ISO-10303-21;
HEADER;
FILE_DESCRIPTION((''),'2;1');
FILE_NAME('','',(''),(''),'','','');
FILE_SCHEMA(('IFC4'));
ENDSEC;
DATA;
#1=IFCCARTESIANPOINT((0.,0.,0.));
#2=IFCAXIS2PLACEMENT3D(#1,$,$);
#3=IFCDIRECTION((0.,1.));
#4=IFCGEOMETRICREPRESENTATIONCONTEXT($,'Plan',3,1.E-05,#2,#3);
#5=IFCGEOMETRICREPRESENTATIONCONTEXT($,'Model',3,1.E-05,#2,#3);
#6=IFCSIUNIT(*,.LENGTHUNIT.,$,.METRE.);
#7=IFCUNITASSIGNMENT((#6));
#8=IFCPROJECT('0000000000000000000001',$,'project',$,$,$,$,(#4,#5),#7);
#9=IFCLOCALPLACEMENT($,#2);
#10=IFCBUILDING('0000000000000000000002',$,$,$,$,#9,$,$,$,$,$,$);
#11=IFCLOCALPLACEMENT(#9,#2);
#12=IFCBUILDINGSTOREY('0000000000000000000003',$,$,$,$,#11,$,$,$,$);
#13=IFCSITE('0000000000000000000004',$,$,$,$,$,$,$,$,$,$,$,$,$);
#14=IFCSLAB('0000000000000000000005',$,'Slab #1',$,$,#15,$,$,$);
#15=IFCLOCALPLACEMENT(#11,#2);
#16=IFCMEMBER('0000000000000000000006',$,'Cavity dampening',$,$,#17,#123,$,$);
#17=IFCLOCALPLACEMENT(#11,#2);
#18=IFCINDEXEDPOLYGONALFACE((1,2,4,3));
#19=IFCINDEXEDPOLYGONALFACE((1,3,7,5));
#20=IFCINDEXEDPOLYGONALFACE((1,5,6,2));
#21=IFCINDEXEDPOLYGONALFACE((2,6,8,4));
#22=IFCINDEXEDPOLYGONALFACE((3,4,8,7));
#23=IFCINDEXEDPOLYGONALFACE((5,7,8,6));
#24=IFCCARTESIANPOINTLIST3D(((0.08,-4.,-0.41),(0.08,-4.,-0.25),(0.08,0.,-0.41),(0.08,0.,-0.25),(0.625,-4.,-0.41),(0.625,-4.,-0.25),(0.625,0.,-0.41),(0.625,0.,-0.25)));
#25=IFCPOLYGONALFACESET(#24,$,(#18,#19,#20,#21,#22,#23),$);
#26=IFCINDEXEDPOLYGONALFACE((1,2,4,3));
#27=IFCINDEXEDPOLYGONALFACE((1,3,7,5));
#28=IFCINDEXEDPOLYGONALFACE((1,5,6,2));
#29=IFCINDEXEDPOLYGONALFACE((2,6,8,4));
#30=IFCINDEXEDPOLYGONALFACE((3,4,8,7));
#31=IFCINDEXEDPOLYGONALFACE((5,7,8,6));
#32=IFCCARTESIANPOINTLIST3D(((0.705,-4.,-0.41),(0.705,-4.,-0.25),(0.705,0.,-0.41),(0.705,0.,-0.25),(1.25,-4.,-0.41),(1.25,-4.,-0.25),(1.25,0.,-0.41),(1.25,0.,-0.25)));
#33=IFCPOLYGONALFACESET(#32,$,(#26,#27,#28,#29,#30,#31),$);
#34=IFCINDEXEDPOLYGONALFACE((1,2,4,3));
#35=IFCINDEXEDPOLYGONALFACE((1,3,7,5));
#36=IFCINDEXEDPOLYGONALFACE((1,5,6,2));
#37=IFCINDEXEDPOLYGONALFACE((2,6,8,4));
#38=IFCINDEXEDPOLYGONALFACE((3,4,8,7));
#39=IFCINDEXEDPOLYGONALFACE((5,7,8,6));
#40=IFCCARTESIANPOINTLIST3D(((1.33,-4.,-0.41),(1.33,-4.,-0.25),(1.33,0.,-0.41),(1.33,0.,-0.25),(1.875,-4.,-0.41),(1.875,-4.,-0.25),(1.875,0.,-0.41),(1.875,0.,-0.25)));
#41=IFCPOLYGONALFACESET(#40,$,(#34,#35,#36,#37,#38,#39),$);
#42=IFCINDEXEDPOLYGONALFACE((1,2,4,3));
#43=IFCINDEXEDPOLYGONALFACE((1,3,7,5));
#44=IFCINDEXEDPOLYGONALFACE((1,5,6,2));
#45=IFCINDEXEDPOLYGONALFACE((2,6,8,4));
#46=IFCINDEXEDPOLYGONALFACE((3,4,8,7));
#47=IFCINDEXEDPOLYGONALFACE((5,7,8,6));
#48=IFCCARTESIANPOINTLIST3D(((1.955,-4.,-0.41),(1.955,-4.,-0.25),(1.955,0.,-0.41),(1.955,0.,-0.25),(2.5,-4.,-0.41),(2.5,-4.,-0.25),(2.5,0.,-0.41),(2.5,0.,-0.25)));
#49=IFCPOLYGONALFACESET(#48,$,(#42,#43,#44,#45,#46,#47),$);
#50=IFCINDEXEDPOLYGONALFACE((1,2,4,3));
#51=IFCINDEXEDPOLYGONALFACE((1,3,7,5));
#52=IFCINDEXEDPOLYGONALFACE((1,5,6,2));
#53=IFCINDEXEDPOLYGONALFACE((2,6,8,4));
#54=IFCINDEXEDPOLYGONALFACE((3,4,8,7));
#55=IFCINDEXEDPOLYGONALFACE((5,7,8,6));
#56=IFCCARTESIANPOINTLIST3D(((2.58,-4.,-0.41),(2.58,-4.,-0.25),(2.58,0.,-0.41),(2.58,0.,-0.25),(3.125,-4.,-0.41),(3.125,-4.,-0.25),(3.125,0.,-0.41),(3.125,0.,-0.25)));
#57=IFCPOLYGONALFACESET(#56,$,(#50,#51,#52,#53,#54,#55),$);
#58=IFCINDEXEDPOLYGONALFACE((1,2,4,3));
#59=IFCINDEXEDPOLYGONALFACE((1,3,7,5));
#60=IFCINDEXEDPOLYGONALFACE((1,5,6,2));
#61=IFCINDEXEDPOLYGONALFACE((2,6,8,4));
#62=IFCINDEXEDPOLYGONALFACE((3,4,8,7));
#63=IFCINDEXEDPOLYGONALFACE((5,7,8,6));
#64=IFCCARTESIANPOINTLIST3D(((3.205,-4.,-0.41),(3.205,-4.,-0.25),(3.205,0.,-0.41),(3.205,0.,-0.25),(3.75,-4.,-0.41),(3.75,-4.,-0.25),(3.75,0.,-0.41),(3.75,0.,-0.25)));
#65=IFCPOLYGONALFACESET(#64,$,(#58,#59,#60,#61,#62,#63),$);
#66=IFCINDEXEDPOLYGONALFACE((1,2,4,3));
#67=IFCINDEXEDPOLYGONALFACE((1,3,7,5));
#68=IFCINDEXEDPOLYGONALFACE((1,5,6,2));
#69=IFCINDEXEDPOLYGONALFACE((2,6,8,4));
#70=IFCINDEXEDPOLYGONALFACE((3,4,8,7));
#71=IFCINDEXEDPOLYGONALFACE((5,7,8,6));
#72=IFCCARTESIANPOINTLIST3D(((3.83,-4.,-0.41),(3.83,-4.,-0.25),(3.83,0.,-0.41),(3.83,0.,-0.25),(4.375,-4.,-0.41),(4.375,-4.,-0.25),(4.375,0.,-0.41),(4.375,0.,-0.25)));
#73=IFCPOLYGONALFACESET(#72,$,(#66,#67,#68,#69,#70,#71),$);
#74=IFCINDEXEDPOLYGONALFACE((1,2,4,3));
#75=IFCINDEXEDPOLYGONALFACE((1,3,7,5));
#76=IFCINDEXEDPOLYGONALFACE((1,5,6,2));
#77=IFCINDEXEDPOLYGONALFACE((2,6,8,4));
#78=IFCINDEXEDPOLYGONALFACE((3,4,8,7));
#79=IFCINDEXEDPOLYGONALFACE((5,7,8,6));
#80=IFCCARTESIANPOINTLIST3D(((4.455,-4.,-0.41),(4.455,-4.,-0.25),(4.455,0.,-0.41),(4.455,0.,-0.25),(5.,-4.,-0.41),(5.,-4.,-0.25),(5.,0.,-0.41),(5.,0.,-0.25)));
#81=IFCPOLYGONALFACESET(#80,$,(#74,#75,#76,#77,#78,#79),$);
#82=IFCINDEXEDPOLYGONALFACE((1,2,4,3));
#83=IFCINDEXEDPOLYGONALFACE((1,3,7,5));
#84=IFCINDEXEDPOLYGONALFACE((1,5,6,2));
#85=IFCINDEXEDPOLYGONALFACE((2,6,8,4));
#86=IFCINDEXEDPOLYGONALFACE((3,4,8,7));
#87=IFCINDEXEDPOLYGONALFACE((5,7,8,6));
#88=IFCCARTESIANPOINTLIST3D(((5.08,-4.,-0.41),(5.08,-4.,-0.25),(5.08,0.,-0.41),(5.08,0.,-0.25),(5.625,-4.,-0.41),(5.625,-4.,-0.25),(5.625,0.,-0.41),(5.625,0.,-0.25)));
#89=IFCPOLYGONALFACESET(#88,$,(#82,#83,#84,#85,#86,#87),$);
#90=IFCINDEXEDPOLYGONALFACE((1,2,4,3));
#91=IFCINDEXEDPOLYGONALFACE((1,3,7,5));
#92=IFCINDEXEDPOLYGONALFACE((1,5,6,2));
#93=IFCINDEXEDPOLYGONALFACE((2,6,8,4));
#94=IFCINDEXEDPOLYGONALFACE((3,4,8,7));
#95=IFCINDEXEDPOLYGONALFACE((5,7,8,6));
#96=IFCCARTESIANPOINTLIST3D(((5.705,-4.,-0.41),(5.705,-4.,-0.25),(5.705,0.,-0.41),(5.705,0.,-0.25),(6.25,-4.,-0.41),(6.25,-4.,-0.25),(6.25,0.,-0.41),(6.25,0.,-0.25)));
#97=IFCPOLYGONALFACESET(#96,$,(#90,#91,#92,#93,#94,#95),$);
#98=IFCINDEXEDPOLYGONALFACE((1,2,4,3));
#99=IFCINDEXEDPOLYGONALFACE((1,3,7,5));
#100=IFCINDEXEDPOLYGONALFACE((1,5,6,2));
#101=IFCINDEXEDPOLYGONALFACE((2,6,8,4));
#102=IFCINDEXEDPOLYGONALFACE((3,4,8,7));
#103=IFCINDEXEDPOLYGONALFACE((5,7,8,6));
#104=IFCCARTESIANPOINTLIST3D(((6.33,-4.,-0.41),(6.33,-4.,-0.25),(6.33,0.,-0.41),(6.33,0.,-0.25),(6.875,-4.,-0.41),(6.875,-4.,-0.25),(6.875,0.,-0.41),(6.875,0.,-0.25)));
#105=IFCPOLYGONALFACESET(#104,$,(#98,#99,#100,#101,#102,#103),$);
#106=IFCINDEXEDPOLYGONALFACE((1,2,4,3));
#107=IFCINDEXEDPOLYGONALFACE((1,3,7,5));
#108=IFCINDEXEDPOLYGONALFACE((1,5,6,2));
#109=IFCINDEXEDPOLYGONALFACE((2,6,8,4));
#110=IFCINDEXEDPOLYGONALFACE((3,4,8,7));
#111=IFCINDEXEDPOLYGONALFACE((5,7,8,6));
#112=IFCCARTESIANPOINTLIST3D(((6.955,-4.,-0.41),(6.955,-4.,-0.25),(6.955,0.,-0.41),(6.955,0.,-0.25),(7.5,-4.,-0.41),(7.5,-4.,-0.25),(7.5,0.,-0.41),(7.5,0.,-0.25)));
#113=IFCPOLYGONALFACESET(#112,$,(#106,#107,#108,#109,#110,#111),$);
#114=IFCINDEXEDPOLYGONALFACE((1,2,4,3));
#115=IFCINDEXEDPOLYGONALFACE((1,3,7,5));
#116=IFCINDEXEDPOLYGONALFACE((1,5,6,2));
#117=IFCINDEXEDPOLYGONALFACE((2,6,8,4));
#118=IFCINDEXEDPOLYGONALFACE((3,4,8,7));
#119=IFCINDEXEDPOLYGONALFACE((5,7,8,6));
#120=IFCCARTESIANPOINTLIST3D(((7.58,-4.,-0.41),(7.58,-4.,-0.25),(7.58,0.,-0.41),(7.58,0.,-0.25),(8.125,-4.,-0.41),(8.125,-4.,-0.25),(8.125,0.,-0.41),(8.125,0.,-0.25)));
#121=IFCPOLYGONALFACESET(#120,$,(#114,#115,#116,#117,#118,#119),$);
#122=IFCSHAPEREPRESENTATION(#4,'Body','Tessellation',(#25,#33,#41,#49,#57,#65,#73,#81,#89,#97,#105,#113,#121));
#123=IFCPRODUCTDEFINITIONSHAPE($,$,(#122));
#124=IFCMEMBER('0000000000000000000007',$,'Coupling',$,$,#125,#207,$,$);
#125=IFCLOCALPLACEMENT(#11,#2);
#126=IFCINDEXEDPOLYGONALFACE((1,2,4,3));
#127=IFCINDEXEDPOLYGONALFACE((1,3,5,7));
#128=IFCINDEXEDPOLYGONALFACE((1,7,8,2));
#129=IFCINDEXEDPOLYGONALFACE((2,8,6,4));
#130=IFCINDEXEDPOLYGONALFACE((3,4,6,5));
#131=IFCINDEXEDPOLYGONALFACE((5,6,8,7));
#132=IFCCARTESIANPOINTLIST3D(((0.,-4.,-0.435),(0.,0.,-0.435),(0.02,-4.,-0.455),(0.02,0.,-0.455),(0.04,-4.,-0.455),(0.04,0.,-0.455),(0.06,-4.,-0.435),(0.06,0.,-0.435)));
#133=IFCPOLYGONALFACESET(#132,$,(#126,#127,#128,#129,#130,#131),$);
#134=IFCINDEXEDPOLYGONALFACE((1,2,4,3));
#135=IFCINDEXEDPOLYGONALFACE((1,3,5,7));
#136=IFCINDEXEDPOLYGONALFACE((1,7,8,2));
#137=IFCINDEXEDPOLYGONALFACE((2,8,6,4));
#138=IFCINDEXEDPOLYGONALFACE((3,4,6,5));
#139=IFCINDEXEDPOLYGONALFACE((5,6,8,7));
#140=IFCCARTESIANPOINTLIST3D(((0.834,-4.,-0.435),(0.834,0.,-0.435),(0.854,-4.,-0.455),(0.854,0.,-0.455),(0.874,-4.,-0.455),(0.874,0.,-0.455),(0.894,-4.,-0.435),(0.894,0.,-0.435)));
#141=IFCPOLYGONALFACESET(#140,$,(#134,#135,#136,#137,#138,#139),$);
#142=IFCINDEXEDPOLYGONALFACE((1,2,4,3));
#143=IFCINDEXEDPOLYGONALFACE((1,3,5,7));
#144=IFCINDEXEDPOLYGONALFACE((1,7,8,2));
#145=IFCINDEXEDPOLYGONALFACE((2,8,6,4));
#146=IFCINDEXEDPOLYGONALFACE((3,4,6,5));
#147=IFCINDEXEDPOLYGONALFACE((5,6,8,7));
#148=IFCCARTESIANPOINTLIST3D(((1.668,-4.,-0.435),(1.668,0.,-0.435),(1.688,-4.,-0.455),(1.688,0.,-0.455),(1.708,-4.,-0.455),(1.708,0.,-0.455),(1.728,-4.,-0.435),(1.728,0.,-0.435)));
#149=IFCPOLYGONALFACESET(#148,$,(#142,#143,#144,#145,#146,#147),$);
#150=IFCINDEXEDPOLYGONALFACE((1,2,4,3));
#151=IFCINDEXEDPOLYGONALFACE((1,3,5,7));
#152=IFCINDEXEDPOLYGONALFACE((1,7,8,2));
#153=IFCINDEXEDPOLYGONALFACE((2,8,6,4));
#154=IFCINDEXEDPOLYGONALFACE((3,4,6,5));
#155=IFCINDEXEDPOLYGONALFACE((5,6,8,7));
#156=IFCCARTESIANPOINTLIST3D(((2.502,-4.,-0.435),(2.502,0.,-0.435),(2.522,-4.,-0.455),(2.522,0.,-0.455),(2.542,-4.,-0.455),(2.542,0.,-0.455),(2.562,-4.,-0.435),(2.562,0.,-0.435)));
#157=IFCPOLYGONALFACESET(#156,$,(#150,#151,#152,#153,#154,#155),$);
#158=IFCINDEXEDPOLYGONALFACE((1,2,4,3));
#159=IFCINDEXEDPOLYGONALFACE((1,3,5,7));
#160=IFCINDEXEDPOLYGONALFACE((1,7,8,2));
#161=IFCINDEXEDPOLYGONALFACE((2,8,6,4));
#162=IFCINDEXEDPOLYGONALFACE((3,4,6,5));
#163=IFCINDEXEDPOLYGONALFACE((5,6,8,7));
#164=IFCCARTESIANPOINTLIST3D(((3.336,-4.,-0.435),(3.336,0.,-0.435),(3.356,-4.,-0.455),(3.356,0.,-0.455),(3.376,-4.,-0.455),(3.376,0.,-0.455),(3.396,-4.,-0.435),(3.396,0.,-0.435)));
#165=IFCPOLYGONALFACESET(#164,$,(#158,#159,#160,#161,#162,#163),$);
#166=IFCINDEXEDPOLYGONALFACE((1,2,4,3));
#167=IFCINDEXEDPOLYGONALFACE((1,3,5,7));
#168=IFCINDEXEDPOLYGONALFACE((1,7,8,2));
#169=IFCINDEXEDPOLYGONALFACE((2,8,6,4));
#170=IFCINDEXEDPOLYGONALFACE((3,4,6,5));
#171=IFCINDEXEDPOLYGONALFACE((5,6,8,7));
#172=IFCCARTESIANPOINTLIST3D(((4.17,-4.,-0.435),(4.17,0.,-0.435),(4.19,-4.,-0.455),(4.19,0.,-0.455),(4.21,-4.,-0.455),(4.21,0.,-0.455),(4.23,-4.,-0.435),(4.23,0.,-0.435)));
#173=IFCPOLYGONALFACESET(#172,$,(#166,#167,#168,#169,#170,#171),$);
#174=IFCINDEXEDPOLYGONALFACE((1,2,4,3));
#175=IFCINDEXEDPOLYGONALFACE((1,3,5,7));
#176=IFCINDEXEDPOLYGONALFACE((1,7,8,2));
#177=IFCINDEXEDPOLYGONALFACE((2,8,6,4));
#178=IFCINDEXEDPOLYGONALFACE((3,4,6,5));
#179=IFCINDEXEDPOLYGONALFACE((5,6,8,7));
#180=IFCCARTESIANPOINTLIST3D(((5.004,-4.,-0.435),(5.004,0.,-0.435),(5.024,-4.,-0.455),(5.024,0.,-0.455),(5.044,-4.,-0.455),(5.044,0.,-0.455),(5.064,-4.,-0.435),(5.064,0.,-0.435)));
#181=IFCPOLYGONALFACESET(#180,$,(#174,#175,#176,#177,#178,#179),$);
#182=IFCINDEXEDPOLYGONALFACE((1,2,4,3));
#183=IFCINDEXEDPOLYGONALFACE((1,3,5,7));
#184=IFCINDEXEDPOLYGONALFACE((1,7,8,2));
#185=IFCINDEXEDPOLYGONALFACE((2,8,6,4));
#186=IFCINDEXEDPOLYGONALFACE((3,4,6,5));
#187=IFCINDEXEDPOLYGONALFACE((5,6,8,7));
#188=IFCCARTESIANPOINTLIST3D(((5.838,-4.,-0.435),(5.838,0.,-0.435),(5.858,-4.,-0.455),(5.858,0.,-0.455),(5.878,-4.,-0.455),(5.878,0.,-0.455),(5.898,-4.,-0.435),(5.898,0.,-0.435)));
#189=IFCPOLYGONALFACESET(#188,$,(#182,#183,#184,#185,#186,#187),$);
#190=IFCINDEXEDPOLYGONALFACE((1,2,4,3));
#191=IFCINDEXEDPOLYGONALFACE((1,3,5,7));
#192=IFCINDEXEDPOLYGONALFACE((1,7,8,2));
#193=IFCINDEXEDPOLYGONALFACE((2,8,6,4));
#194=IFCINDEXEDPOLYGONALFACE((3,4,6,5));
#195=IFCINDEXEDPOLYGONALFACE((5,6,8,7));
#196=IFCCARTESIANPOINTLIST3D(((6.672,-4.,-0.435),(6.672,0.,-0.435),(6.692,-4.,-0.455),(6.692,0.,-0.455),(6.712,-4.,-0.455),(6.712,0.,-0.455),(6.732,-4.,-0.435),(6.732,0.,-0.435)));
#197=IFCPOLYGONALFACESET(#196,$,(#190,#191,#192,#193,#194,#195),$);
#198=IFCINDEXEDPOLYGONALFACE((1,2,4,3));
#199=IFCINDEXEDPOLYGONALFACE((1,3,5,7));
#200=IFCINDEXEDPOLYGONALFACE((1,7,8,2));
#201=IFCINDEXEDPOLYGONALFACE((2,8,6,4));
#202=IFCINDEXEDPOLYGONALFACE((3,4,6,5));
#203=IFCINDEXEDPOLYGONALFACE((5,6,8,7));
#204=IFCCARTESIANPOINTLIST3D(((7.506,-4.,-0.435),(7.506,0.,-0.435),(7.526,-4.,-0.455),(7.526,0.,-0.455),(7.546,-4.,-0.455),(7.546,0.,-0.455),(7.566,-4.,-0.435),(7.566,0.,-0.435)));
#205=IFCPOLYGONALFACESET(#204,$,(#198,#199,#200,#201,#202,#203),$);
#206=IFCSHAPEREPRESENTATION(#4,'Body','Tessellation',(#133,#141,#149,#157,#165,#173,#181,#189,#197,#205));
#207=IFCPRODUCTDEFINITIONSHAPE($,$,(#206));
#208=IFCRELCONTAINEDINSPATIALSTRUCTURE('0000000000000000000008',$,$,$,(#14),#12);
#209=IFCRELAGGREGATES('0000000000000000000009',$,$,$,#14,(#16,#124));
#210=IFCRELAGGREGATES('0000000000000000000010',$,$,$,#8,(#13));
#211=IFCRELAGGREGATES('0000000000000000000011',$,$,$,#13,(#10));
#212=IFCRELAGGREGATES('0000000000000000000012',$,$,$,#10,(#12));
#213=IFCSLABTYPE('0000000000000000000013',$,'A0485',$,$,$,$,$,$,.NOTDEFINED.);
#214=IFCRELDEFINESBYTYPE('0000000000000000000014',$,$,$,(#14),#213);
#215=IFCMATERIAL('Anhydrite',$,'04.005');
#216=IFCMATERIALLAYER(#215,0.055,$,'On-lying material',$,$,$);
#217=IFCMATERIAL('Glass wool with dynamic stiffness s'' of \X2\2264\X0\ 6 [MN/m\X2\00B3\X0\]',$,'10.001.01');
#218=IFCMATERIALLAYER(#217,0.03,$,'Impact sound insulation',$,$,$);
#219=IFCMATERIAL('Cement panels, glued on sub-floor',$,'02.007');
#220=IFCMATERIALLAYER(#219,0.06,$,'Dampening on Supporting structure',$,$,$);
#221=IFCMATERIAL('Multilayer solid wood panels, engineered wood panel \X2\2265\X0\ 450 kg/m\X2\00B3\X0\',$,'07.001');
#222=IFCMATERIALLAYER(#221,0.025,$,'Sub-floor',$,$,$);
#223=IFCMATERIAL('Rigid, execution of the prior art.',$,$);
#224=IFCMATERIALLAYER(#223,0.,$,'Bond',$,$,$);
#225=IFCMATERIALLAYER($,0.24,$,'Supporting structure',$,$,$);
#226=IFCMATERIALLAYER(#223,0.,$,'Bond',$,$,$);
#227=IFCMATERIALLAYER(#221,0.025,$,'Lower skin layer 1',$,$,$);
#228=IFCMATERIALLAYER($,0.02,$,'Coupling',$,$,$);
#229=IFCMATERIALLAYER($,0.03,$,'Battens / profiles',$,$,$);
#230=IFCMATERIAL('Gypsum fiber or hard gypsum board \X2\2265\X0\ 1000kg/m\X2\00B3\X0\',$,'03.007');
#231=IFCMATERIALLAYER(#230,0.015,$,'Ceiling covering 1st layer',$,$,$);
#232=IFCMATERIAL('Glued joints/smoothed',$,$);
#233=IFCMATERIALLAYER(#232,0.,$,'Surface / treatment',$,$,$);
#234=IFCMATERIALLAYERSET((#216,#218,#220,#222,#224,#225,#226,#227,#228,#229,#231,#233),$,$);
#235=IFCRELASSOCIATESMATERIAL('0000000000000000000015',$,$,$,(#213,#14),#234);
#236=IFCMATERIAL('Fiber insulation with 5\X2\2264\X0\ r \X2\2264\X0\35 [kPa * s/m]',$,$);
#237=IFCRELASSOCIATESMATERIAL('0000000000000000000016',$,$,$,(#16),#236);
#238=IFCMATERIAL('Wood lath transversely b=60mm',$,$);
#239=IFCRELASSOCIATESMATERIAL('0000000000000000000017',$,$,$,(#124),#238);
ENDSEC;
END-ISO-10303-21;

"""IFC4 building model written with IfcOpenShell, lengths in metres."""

from ifc_helpers import new_model, si_unit, direction, frame, frame_2d, origin, place, context, project, spatial, polyline, rectangle, outline, extrude, material, layer, layer_set, type_object, element, aggregate, save


model = new_model("IFC4")

# Units and contexts
plan_context = context("Plan", 3, precision=1e-05, world=origin(), true_north=direction((0.0, 1.0)))
model_context = context("Model", 3, precision=1e-05, world=origin(), true_north=direction((0.0, 1.0)))
ifc_project = project(units=[si_unit("LENGTHUNIT", "METRE")], contexts=[plan_context, model_context])

# Site, building, storey
site = spatial("IfcSite", under=ifc_project)
building_placement = place(None, origin())
building = spatial("IfcBuilding", under=site, at=building_placement)
storey_placement = place(building_placement, origin())
storey = spatial("IfcBuildingStorey", under=building, at=storey_placement)

# Slab, members
ifc_material_1 = material(Name="Anhydrite", Category="04.005")
ifc_layer_1 = layer(ifc_material_1, 0.055, Name="On-lying material")
ifc_material_2 = material(Name="Glass wool with dynamic stiffness s' of ≤ 6 [MN/m³]", Category="10.001.01")
ifc_layer_2 = layer(ifc_material_2, 0.03, Name="Impact sound insulation")
ifc_material_3 = material(Name="Cement panels, glued on sub-floor", Category="02.007")
ifc_layer_3 = layer(ifc_material_3, 0.06, Name="Dampening on Supporting structure")
ifc_material_4 = material(Name="Multilayer solid wood panels, engineered wood panel ≥ 450 kg/m³", Category="07.001")
ifc_layer_4 = layer(ifc_material_4, 0.025, Name="Sub-floor")
ifc_material_5 = material(Name="Rigid, execution of the prior art.")
ifc_layer_5 = layer(ifc_material_5, 0.0, Name="Bond")
ifc_layer_6 = layer(None, 0.24, Name="Supporting structure")
ifc_layer_7 = layer(ifc_material_5, 0.0, Name="Bond")
ifc_layer_8 = layer(ifc_material_4, 0.025, Name="Lower skin layer 1")
ifc_layer_9 = layer(None, 0.02, Name="Coupling")
ifc_layer_10 = layer(None, 0.03, Name="Battens / profiles")
ifc_material_6 = material(Name="Gypsum fiber or hard gypsum board ≥ 1000kg/m³", Category="03.007")
ifc_layer_11 = layer(ifc_material_6, 0.015, Name="Ceiling covering 1st layer")
ifc_material_7 = material(Name="Glued joints/smoothed")
ifc_layer_12 = layer(ifc_material_7, 0.0, Name="Surface / treatment")
ifc_layer_set = layer_set([ifc_layer_1, ifc_layer_2, ifc_layer_3, ifc_layer_4, ifc_layer_5, ifc_layer_6, ifc_layer_7, ifc_layer_8, ifc_layer_9, ifc_layer_10, ifc_layer_11, ifc_layer_12])
slab_type = type_object("IfcSlabType", Name="A0485", PredefinedType="NOTDEFINED", material=ifc_layer_set)
slab_placement = place(None, frame((0.0, 0.0, 0.0), z_axis=(0.0, 0.0, -1.0), x_axis=(1.0, 0.0, 0.0)))
slab = element("IfcSlab", 1, at=slab_placement, inside=storey, type_object=slab_type, material=ifc_layer_set, Name="Slab #1")
ifc_material_8 = material(Name="Fiber insulation with 5≤ r ≤35 [kPa * s/m]")
member_1_placement = place(slab_placement, origin())
member_1 = element("IfcMember", 2, at=member_1_placement, material=ifc_material_8, Name="Cavity dampening", context=plan_context, shape_type="SweptSolid", body=[
    extrude(rectangle(XDim=0.545, YDim=0.16, at=frame_2d((0.2725, 0.08), x_axis=(1.0, 0.0))), frame((0.08, 4.0, 0.25), z_axis=(0.0, -1.0, 0.0), x_axis=(1.0, 0.0, 0.0)), (0.0, 0.0, 1.0), 4.0),
    extrude(rectangle(XDim=0.545, YDim=0.16, at=frame_2d((0.2725, 0.08), x_axis=(1.0, 0.0))), frame((0.705, 4.0, 0.25), z_axis=(0.0, -1.0, 0.0), x_axis=(1.0, 0.0, 0.0)), (0.0, 0.0, 1.0), 4.0),
    extrude(rectangle(XDim=0.545, YDim=0.16, at=frame_2d((0.2725, 0.08), x_axis=(1.0, 0.0))), frame((1.33, 4.0, 0.25), z_axis=(0.0, -1.0, 0.0), x_axis=(1.0, 0.0, 0.0)), (0.0, 0.0, 1.0), 4.0),
    extrude(rectangle(XDim=0.545, YDim=0.16, at=frame_2d((0.2725, 0.08), x_axis=(1.0, 0.0))), frame((1.955, 4.0, 0.25), z_axis=(0.0, -1.0, 0.0), x_axis=(1.0, 0.0, 0.0)), (0.0, 0.0, 1.0), 4.0),
    extrude(rectangle(XDim=0.545, YDim=0.16, at=frame_2d((0.2725, 0.08), x_axis=(1.0, 0.0))), frame((2.58, 4.0, 0.25), z_axis=(0.0, -1.0, 0.0), x_axis=(1.0, 0.0, 0.0)), (0.0, 0.0, 1.0), 4.0),
    extrude(rectangle(XDim=0.545, YDim=0.16, at=frame_2d((0.2725, 0.08), x_axis=(1.0, 0.0))), frame((3.205, 4.0, 0.25), z_axis=(0.0, -1.0, 0.0), x_axis=(1.0, 0.0, 0.0)), (0.0, 0.0, 1.0), 4.0),
    extrude(rectangle(XDim=0.545, YDim=0.16, at=frame_2d((0.2725, 0.08), x_axis=(1.0, 0.0))), frame((3.83, 4.0, 0.25), z_axis=(0.0, -1.0, 0.0), x_axis=(1.0, 0.0, 0.0)), (0.0, 0.0, 1.0), 4.0),
    extrude(rectangle(XDim=0.545, YDim=0.16, at=frame_2d((0.2725, 0.08), x_axis=(1.0, 0.0))), frame((4.455, 4.0, 0.25), z_axis=(0.0, -1.0, 0.0), x_axis=(1.0, 0.0, 0.0)), (0.0, 0.0, 1.0), 4.0),
    extrude(rectangle(XDim=0.545, YDim=0.16, at=frame_2d((0.2725, 0.08), x_axis=(1.0, 0.0))), frame((5.08, 4.0, 0.25), z_axis=(0.0, -1.0, 0.0), x_axis=(1.0, 0.0, 0.0)), (0.0, 0.0, 1.0), 4.0),
    extrude(rectangle(XDim=0.545, YDim=0.16, at=frame_2d((0.2725, 0.08), x_axis=(1.0, 0.0))), frame((5.705, 4.0, 0.25), z_axis=(0.0, -1.0, 0.0), x_axis=(1.0, 0.0, 0.0)), (0.0, 0.0, 1.0), 4.0),
    extrude(rectangle(XDim=0.545, YDim=0.16, at=frame_2d((0.2725, 0.08), x_axis=(1.0, 0.0))), frame((6.33, 4.0, 0.25), z_axis=(0.0, -1.0, 0.0), x_axis=(1.0, 0.0, 0.0)), (0.0, 0.0, 1.0), 4.0),
    extrude(rectangle(XDim=0.545, YDim=0.16, at=frame_2d((0.2725, 0.08), x_axis=(1.0, 0.0))), frame((6.955, 4.0, 0.25), z_axis=(0.0, -1.0, 0.0), x_axis=(1.0, 0.0, 0.0)), (0.0, 0.0, 1.0), 4.0),
    extrude(rectangle(XDim=0.545, YDim=0.16, at=frame_2d((0.2725, 0.08), x_axis=(1.0, 0.0))), frame((7.58, 4.0, 0.25), z_axis=(0.0, -1.0, 0.0), x_axis=(1.0, 0.0, 0.0)), (0.0, 0.0, 1.0), 4.0),
])
ifc_material_9 = material(Name="Wood lath transversely b=60mm")
member_2_placement = place(slab_placement, origin())
member_2 = element("IfcMember", 3, at=member_2_placement, material=ifc_material_9, Name="Coupling", context=plan_context, shape_type="SweptSolid", body=[
    extrude(outline(polyline([(0.0, 0.0), (0.06, 0.0), (0.04, 0.02), (0.02, 0.02), (0.0, 0.0)])), frame((0.0, 4.0, 0.435), z_axis=(0.0, -1.0, 0.0), x_axis=(1.0, 0.0, 0.0)), (0.0, 0.0, 1.0), 4.0),
    extrude(outline(polyline([(0.0, 0.0), (0.06, 0.0), (0.04, 0.02), (0.02, 0.02), (0.0, 0.0)])), frame((0.834, 4.0, 0.435), z_axis=(0.0, -1.0, 0.0), x_axis=(1.0, 0.0, 0.0)), (0.0, 0.0, 1.0), 4.0),
    extrude(outline(polyline([(0.0, 0.0), (0.06, 0.0), (0.04, 0.02), (0.02, 0.02), (0.0, 0.0)])), frame((1.668, 4.0, 0.435), z_axis=(0.0, -1.0, 0.0), x_axis=(1.0, 0.0, 0.0)), (0.0, 0.0, 1.0), 4.0),
    extrude(outline(polyline([(0.0, 0.0), (0.06, 0.0), (0.04, 0.02), (0.02, 0.02), (0.0, 0.0)])), frame((2.502, 4.0, 0.435), z_axis=(0.0, -1.0, 0.0), x_axis=(1.0, 0.0, 0.0)), (0.0, 0.0, 1.0), 4.0),
    extrude(outline(polyline([(0.0, 0.0), (0.06, 0.0), (0.04, 0.02), (0.02, 0.02), (0.0, 0.0)])), frame((3.336, 4.0, 0.435), z_axis=(0.0, -1.0, 0.0), x_axis=(1.0, 0.0, 0.0)), (0.0, 0.0, 1.0), 4.0),
    extrude(outline(polyline([(0.0, 0.0), (0.06, 0.0), (0.04, 0.02), (0.02, 0.02), (0.0, 0.0)])), frame((4.17, 4.0, 0.435), z_axis=(0.0, -1.0, 0.0), x_axis=(1.0, 0.0, 0.0)), (0.0, 0.0, 1.0), 4.0),
    extrude(outline(polyline([(0.0, 0.0), (0.06, 0.0), (0.04, 0.02), (0.02, 0.02), (0.0, 0.0)])), frame((5.004, 4.0, 0.435), z_axis=(0.0, -1.0, 0.0), x_axis=(1.0, 0.0, 0.0)), (0.0, 0.0, 1.0), 4.0),
    extrude(outline(polyline([(0.0, 0.0), (0.06, 0.0), (0.04, 0.02), (0.02, 0.02), (0.0, 0.0)])), frame((5.838, 4.0, 0.435), z_axis=(0.0, -1.0, 0.0), x_axis=(1.0, 0.0, 0.0)), (0.0, 0.0, 1.0), 4.0),
    extrude(outline(polyline([(0.0, 0.0), (0.06, 0.0), (0.04, 0.02), (0.02, 0.02), (0.0, 0.0)])), frame((6.672, 4.0, 0.435), z_axis=(0.0, -1.0, 0.0), x_axis=(1.0, 0.0, 0.0)), (0.0, 0.0, 1.0), 4.0),
    extrude(outline(polyline([(0.0, 0.0), (0.06, 0.0), (0.04, 0.02), (0.02, 0.02), (0.0, 0.0)])), frame((7.506, 4.0, 0.435), z_axis=(0.0, -1.0, 0.0), x_axis=(1.0, 0.0, 0.0)), (0.0, 0.0, 1.0), 4.0),
])
aggregate(slab, [member_1, member_2])

save(model, "model.ifc")
